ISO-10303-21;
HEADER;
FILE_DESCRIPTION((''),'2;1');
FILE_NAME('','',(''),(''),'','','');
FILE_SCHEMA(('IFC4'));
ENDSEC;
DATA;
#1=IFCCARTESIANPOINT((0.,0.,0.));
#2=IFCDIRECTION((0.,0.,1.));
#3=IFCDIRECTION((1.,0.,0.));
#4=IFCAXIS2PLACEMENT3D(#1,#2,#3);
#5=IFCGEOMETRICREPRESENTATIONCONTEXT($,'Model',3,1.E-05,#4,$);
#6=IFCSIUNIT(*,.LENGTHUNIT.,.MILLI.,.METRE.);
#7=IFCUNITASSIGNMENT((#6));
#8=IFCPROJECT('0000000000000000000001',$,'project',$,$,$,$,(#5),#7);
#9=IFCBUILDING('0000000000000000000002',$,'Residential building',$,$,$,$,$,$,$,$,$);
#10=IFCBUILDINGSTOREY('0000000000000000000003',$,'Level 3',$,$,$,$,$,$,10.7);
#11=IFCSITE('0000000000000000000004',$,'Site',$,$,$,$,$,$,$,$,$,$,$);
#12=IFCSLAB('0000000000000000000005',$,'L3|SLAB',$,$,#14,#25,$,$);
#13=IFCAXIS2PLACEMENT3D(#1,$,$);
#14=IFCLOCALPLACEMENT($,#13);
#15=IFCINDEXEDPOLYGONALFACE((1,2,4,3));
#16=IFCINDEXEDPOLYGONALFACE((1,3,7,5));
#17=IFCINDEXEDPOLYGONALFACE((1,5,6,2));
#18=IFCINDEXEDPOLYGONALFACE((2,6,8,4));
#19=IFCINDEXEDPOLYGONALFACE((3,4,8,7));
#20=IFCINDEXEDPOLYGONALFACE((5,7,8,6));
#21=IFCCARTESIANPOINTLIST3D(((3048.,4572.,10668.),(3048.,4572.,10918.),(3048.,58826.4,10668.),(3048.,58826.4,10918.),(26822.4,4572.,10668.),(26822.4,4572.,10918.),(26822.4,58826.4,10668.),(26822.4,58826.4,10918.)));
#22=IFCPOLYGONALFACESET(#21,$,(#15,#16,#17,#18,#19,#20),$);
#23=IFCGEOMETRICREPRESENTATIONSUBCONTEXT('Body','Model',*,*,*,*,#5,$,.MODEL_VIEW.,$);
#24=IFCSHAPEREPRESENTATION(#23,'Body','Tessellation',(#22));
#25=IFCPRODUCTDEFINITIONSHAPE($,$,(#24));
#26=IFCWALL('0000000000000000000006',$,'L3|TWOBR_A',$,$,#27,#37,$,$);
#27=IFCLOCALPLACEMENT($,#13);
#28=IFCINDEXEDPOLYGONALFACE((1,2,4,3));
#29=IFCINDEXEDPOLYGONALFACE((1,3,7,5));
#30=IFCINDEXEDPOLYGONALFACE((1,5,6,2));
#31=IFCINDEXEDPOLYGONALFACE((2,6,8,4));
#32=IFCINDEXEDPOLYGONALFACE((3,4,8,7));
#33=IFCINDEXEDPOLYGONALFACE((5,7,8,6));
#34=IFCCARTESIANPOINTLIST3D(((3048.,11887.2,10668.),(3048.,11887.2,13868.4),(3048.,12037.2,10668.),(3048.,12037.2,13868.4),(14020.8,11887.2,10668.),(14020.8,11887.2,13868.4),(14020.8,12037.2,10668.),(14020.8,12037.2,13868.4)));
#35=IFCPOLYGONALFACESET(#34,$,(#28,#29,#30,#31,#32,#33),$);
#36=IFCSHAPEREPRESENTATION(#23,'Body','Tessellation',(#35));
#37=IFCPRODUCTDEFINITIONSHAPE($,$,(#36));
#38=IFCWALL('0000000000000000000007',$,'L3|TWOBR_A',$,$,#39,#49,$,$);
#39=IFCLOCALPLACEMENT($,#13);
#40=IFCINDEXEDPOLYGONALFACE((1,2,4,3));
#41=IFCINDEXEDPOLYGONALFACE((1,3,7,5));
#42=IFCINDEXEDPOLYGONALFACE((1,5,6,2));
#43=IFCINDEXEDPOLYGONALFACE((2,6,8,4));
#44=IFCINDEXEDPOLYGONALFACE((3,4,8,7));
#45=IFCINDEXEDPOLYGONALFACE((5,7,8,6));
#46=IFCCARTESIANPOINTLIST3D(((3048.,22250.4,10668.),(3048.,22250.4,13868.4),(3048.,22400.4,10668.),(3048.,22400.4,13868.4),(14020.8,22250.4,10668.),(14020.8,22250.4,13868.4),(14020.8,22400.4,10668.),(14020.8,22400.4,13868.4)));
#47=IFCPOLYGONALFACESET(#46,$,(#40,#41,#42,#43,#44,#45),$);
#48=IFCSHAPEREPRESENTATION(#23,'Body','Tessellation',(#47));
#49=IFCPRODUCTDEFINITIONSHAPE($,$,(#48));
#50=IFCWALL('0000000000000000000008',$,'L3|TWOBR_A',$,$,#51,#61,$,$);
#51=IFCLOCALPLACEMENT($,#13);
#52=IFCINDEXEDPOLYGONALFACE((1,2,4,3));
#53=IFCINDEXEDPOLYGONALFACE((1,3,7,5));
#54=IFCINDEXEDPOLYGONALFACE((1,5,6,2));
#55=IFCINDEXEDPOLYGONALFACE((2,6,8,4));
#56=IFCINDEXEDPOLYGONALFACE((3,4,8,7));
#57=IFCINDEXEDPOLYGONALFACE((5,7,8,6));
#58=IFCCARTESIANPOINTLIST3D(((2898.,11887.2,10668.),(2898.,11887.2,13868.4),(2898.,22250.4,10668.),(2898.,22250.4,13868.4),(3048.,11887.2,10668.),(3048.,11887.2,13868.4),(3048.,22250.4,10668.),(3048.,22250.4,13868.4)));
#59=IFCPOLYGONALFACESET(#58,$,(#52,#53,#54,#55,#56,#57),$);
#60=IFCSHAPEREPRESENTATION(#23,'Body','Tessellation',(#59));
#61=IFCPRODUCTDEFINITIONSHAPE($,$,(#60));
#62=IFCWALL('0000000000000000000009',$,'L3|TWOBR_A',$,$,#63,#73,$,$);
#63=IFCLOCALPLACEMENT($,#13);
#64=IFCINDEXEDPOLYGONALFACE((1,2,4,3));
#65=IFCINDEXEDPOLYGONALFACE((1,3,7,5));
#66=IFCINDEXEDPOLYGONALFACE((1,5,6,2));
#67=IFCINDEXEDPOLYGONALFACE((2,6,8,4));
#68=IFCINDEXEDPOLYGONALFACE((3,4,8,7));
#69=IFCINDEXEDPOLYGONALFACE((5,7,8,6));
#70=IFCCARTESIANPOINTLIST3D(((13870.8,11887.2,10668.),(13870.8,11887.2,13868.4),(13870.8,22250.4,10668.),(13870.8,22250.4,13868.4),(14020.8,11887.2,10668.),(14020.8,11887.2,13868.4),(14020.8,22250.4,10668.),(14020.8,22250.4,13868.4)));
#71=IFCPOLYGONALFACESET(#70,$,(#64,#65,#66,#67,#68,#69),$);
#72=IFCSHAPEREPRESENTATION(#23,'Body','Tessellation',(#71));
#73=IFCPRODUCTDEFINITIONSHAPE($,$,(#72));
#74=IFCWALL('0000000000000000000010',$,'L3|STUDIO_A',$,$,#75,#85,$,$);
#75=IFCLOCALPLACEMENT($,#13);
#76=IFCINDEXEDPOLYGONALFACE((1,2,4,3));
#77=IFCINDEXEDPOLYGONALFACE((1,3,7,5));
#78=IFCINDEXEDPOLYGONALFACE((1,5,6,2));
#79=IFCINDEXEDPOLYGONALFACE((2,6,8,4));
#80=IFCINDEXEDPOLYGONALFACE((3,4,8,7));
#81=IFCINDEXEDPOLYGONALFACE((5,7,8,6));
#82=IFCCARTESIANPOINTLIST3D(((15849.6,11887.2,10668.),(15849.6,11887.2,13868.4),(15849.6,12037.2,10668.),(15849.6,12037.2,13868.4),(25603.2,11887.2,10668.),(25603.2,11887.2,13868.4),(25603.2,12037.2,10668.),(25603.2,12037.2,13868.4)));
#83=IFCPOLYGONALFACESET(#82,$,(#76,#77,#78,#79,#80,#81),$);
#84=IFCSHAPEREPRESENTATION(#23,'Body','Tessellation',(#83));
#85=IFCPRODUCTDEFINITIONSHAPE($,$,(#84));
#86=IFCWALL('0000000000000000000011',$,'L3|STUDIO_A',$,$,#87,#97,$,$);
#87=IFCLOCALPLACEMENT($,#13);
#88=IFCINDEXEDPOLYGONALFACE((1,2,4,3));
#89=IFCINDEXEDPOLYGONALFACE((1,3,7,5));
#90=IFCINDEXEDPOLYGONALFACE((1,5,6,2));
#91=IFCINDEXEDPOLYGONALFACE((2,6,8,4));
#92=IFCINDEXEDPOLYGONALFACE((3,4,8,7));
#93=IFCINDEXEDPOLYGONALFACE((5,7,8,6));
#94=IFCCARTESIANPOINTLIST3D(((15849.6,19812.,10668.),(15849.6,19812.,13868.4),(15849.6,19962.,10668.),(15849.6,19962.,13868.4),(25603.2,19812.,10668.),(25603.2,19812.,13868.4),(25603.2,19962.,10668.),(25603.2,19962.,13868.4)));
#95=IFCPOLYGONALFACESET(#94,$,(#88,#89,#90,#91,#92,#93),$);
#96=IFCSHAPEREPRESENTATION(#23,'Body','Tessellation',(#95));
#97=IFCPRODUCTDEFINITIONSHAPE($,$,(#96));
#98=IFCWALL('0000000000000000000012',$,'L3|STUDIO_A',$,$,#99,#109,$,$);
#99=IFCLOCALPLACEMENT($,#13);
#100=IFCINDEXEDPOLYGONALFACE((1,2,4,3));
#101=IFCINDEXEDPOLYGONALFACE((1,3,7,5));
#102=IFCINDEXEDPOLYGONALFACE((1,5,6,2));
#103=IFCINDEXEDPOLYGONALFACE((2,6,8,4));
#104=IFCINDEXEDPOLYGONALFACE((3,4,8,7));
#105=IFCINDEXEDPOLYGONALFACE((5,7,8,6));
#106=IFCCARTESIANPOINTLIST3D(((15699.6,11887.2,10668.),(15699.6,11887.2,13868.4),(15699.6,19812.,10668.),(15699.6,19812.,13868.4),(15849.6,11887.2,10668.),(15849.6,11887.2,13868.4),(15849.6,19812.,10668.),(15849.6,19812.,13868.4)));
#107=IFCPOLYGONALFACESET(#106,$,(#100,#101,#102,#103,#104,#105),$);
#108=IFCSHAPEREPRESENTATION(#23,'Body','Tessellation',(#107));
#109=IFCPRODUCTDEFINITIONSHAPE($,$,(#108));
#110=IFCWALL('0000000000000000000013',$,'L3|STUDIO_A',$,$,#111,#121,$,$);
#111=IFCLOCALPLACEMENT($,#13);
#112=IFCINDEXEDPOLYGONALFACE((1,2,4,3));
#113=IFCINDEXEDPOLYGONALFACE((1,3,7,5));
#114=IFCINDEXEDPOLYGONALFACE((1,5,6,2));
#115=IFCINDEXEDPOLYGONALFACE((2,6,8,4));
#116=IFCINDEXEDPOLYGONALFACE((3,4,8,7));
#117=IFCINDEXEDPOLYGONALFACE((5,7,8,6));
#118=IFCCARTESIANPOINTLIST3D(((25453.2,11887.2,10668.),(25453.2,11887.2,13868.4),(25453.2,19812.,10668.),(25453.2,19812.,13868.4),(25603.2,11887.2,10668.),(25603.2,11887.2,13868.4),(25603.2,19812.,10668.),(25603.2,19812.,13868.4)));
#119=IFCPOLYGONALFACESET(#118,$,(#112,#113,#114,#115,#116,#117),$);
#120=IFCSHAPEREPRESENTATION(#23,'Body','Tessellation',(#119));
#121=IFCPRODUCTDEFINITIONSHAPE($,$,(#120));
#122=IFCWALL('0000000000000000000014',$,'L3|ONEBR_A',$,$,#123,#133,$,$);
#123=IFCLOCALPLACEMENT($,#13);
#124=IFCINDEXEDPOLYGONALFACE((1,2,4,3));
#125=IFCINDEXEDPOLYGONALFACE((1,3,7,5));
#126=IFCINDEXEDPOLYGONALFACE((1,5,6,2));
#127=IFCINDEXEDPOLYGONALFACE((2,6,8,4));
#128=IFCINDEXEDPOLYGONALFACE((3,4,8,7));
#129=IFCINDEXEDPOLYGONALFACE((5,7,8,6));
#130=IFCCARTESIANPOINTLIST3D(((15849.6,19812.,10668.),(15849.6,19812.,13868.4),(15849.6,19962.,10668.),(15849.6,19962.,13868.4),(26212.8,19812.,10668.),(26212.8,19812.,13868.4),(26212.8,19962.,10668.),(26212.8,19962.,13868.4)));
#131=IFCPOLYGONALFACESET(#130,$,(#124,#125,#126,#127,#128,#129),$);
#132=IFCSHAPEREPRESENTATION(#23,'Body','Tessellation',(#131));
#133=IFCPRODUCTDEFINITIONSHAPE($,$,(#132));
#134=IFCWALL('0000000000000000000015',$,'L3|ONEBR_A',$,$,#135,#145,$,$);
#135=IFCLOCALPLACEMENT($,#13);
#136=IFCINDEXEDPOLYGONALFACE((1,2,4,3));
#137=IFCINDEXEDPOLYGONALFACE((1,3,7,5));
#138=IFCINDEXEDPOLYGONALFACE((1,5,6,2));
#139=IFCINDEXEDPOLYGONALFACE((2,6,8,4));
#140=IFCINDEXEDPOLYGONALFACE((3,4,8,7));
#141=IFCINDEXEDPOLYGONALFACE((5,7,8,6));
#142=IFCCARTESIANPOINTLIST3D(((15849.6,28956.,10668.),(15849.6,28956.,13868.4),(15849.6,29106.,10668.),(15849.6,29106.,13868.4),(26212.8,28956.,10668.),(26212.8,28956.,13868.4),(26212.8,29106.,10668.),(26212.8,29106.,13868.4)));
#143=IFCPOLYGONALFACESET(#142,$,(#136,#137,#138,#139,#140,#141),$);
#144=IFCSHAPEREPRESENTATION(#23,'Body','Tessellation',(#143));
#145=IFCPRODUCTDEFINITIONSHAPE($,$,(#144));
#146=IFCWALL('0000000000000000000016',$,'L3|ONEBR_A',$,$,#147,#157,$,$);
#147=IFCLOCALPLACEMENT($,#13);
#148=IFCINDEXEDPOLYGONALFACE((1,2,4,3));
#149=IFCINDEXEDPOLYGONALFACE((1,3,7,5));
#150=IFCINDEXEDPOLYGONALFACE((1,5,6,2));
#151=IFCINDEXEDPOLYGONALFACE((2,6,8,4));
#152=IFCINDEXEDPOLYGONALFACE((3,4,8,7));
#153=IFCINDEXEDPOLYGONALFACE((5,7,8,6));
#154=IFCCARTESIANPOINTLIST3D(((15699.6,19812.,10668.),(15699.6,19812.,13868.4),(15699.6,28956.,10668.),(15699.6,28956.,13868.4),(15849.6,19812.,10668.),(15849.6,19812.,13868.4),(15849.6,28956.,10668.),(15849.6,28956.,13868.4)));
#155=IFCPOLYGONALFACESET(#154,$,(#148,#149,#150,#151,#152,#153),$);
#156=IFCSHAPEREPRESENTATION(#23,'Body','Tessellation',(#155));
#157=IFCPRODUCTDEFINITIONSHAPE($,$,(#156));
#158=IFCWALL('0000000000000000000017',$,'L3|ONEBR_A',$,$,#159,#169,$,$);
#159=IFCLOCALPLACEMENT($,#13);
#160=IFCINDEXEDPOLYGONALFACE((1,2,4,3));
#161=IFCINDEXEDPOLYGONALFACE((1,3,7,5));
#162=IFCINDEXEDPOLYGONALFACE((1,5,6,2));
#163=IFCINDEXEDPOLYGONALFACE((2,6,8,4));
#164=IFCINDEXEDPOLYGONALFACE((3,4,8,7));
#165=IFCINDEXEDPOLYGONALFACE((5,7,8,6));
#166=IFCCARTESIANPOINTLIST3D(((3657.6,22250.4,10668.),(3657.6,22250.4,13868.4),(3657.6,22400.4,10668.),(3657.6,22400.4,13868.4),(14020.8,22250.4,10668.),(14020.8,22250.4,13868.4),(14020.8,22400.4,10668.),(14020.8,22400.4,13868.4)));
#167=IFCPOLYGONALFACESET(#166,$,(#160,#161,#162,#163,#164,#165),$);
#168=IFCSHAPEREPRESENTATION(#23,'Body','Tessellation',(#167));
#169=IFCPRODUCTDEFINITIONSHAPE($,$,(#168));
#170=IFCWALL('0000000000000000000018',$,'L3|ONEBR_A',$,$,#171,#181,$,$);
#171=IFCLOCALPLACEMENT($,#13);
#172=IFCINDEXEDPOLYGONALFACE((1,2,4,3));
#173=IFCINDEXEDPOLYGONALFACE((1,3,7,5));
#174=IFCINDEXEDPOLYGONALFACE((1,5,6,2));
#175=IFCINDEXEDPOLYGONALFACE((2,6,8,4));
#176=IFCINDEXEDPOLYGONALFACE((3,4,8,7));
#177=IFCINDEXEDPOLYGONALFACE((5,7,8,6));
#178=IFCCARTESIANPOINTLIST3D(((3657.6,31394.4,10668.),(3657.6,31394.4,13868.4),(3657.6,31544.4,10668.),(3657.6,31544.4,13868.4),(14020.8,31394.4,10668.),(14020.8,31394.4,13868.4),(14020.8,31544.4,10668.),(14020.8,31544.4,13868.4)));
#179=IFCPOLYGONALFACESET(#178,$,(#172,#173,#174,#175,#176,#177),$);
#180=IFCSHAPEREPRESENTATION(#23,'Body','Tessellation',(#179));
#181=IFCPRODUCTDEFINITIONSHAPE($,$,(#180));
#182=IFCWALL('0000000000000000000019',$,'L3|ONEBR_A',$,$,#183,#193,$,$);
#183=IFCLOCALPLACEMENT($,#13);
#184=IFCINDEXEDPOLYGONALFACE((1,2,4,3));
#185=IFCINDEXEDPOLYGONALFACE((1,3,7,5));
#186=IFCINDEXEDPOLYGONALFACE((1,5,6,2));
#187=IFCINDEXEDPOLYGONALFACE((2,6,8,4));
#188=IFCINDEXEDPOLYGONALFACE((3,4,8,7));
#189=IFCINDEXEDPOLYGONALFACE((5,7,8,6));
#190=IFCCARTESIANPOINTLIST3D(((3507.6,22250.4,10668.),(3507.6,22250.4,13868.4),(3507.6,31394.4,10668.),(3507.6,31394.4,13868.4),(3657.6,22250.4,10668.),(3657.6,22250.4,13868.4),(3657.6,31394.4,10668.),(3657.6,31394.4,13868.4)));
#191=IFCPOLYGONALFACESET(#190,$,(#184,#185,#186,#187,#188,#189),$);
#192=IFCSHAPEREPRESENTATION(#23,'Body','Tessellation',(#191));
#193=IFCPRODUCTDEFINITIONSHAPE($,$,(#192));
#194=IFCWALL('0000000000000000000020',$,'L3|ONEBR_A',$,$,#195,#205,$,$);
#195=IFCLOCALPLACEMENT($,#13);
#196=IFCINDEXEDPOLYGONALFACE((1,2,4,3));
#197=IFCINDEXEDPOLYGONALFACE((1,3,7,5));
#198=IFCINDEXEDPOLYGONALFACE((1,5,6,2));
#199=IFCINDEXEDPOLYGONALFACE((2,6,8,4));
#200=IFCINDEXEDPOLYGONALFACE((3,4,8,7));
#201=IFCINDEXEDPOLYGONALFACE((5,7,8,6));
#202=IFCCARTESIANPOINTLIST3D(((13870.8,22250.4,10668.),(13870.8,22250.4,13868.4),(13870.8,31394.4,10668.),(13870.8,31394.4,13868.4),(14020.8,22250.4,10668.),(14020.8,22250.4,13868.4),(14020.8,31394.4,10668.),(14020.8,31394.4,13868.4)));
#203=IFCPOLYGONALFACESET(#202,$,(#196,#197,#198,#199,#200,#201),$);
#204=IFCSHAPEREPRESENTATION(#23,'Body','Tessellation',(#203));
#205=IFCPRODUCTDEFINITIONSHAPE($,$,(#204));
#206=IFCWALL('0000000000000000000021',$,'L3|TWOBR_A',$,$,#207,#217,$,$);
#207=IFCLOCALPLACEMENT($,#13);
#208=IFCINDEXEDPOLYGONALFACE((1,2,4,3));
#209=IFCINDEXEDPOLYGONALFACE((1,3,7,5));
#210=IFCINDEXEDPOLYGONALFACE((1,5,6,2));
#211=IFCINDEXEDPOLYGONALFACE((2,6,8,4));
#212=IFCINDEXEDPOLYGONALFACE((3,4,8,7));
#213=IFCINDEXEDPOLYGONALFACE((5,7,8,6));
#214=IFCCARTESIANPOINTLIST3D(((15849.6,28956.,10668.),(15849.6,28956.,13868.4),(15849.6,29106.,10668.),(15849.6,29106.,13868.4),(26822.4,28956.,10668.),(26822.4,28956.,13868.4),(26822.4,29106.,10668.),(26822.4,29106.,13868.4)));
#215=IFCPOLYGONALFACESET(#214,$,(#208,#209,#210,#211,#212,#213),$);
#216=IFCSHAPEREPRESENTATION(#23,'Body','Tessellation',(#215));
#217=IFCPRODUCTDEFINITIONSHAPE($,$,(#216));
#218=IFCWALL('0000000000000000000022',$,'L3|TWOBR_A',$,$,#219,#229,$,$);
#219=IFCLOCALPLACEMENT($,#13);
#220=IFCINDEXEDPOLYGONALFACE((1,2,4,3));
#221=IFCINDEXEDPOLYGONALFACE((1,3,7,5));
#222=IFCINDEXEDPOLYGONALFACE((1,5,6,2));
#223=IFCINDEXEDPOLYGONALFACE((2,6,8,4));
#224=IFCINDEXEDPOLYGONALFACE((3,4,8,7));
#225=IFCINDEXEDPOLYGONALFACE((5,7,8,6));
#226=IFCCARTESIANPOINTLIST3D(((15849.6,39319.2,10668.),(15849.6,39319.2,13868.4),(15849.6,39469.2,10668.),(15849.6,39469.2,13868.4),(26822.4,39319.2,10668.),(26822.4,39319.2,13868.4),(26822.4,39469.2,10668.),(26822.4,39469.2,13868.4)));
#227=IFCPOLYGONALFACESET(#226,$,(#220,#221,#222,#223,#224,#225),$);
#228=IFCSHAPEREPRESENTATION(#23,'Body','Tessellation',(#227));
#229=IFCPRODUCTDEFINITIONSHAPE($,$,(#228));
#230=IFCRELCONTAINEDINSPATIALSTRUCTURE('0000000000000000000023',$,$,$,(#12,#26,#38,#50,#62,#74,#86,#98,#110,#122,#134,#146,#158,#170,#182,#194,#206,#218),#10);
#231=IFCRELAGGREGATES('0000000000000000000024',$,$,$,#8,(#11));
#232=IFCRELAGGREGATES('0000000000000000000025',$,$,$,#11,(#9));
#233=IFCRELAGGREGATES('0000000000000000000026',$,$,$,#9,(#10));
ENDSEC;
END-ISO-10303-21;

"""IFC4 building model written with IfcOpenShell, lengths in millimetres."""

from ifc_helpers import new_model, si_unit, frame, origin_with_axes, place, context, subcontext, project, spatial, indexed_curve, outline, extrude, element, save


model = new_model("IFC4")

# Units and contexts
model_context = context("Model", 3, precision=1e-05, world=origin_with_axes())
body_context = subcontext(model_context, "Body", "Model", "MODEL_VIEW")
ifc_project = project(units=[si_unit("LENGTHUNIT", "METRE", prefix="MILLI")], contexts=[model_context])

# Site, building, storey
site = spatial("IfcSite", under=ifc_project, Name="Site")
building = spatial("IfcBuilding", under=site, Name="Residential building")
storey = spatial("IfcBuildingStorey", under=building, Name="Level 3", Elevation=10.7)

# Slab
slab_placement = place(None, frame((3048.0, 4572.0, 10668.0), z_axis=(0.0, 0.0, 1.0), x_axis=(1.0, 0.0, 0.0)))
element("IfcSlab", 1, at=slab_placement, inside=storey, Name="L3|SLAB", context=body_context, shape_type="SweptSolid", body=[
    extrude(outline(indexed_curve([(0.0, 0.0), (23774.4, 0.0), (23774.4, 54254.4), (0.0, 54254.4), (0.0, 0.0)])), None, (0.0, 0.0, 1.0), 250.0),
])

# Walls
for number, where, z_axis, x_axis, name in (
    (2, (3048.0, 11887.2, 10668.0), (0.0, 0.0, 1.0), (1.0, 0.0, 0.0), "L3|TWOBR_A"),
    (3, (3048.0, 22250.4, 10668.0), (0.0, 0.0, 1.0), (1.0, 0.0, 0.0), "L3|TWOBR_A"),
):
    element("IfcWall", number, at=place(None, frame(where, z_axis=z_axis, x_axis=x_axis)), inside=storey, Name=name, context=body_context, shape_type="SweptSolid", body=[
        extrude(outline(indexed_curve([(0.0, 0.0), (0.0, 150.0), (10972.8, 150.0), (10972.8, 0.0), (0.0, 0.0)], self_intersect=False)), origin_with_axes(), (0.0, 0.0, 1.0), 3200.4),
    ])
for number, where, z_axis, x_axis, name in (
    (4, (3048.0, 11887.2, 10668.0), (0.0, 0.0, 1.0), (0.0, 1.0, 0.0), "L3|TWOBR_A"),
    (5, (14020.8, 11887.2, 10668.0), (0.0, 0.0, 1.0), (0.0, 1.0, 0.0), "L3|TWOBR_A"),
):
    element("IfcWall", number, at=place(None, frame(where, z_axis=z_axis, x_axis=x_axis)), inside=storey, Name=name, context=body_context, shape_type="SweptSolid", body=[
        extrude(outline(indexed_curve([(0.0, 0.0), (0.0, 150.0), (10363.2, 150.0), (10363.2, 0.0), (0.0, 0.0)], self_intersect=False)), origin_with_axes(), (0.0, 0.0, 1.0), 3200.4),
    ])
for number, where, z_axis, x_axis, name in (
    (6, (15849.6, 11887.2, 10668.0), (0.0, 0.0, 1.0), (1.0, 0.0, 0.0), "L3|STUDIO_A"),
    (7, (15849.6, 19812.0, 10668.0), (0.0, 0.0, 1.0), (1.0, 0.0, 0.0), "L3|STUDIO_A"),
):
    element("IfcWall", number, at=place(None, frame(where, z_axis=z_axis, x_axis=x_axis)), inside=storey, Name=name, context=body_context, shape_type="SweptSolid", body=[
        extrude(outline(indexed_curve([(0.0, 0.0), (0.0, 150.0), (9753.6, 150.0), (9753.6, 0.0), (0.0, 0.0)], self_intersect=False)), origin_with_axes(), (0.0, 0.0, 1.0), 3200.4),
    ])
for number, where, z_axis, x_axis, name in (
    (8, (15849.6, 11887.2, 10668.0), (0.0, 0.0, 1.0), (0.0, 1.0, 0.0), "L3|STUDIO_A"),
    (9, (25603.2, 11887.2, 10668.0), (0.0, 0.0, 1.0), (0.0, 1.0, 0.0), "L3|STUDIO_A"),
):
    element("IfcWall", number, at=place(None, frame(where, z_axis=z_axis, x_axis=x_axis)), inside=storey, Name=name, context=body_context, shape_type="SweptSolid", body=[
        extrude(outline(indexed_curve([(0.0, 0.0), (0.0, 150.0), (7924.8, 150.0), (7924.8, 0.0), (0.0, 0.0)], self_intersect=False)), origin_with_axes(), (0.0, 0.0, 1.0), 3200.4),
    ])
for number, where, z_axis, x_axis, name in (
    (10, (15849.6, 19812.0, 10668.0), (0.0, 0.0, 1.0), (1.0, 0.0, 0.0), "L3|ONEBR_A"),
    (11, (15849.6, 28956.0, 10668.0), (0.0, 0.0, 1.0), (1.0, 0.0, 0.0), "L3|ONEBR_A"),
):
    element("IfcWall", number, at=place(None, frame(where, z_axis=z_axis, x_axis=x_axis)), inside=storey, Name=name, context=body_context, shape_type="SweptSolid", body=[
        extrude(outline(indexed_curve([(0.0, 0.0), (0.0, 150.0), (10363.2, 150.0), (10363.2, 0.0), (0.0, 0.0)], self_intersect=False)), origin_with_axes(), (0.0, 0.0, 1.0), 3200.4),
    ])
wall_placement = place(None, frame((15849.6, 19812.0, 10668.0), z_axis=(0.0, 0.0, 1.0), x_axis=(0.0, 1.0, 0.0)))
element("IfcWall", 12, at=wall_placement, inside=storey, Name="L3|ONEBR_A", context=body_context, shape_type="SweptSolid", body=[
    extrude(outline(indexed_curve([(0.0, 0.0), (0.0, 150.0), (9144.0, 150.0), (9144.0, 0.0), (0.0, 0.0)], self_intersect=False)), origin_with_axes(), (0.0, 0.0, 1.0), 3200.4),
])
for number, where, z_axis, x_axis, name in (
    (13, (3657.6, 22250.4, 10668.0), (0.0, 0.0, 1.0), (1.0, 0.0, 0.0), "L3|ONEBR_A"),
    (14, (3657.6, 31394.4, 10668.0), (0.0, 0.0, 1.0), (1.0, 0.0, 0.0), "L3|ONEBR_A"),
):
    element("IfcWall", number, at=place(None, frame(where, z_axis=z_axis, x_axis=x_axis)), inside=storey, Name=name, context=body_context, shape_type="SweptSolid", body=[
        extrude(outline(indexed_curve([(0.0, 0.0), (0.0, 150.0), (10363.2, 150.0), (10363.2, 0.0), (0.0, 0.0)], self_intersect=False)), origin_with_axes(), (0.0, 0.0, 1.0), 3200.4),
    ])
for number, where, z_axis, x_axis, name in (
    (15, (3657.6, 22250.4, 10668.0), (0.0, 0.0, 1.0), (0.0, 1.0, 0.0), "L3|ONEBR_A"),
    (16, (14020.8, 22250.4, 10668.0), (0.0, 0.0, 1.0), (0.0, 1.0, 0.0), "L3|ONEBR_A"),
):
    element("IfcWall", number, at=place(None, frame(where, z_axis=z_axis, x_axis=x_axis)), inside=storey, Name=name, context=body_context, shape_type="SweptSolid", body=[
        extrude(outline(indexed_curve([(0.0, 0.0), (0.0, 150.0), (9144.0, 150.0), (9144.0, 0.0), (0.0, 0.0)], self_intersect=False)), origin_with_axes(), (0.0, 0.0, 1.0), 3200.4),
    ])
for number, where, z_axis, x_axis, name in (
    (17, (15849.6, 28956.0, 10668.0), (0.0, 0.0, 1.0), (1.0, 0.0, 0.0), "L3|TWOBR_A"),
    (18, (15849.6, 39319.2, 10668.0), (0.0, 0.0, 1.0), (1.0, 0.0, 0.0), "L3|TWOBR_A"),
):
    element("IfcWall", number, at=place(None, frame(where, z_axis=z_axis, x_axis=x_axis)), inside=storey, Name=name, context=body_context, shape_type="SweptSolid", body=[
        extrude(outline(indexed_curve([(0.0, 0.0), (0.0, 150.0), (10972.8, 150.0), (10972.8, 0.0), (0.0, 0.0)], self_intersect=False)), origin_with_axes(), (0.0, 0.0, 1.0), 3200.4),
    ])

save(model, "model.ifc")
